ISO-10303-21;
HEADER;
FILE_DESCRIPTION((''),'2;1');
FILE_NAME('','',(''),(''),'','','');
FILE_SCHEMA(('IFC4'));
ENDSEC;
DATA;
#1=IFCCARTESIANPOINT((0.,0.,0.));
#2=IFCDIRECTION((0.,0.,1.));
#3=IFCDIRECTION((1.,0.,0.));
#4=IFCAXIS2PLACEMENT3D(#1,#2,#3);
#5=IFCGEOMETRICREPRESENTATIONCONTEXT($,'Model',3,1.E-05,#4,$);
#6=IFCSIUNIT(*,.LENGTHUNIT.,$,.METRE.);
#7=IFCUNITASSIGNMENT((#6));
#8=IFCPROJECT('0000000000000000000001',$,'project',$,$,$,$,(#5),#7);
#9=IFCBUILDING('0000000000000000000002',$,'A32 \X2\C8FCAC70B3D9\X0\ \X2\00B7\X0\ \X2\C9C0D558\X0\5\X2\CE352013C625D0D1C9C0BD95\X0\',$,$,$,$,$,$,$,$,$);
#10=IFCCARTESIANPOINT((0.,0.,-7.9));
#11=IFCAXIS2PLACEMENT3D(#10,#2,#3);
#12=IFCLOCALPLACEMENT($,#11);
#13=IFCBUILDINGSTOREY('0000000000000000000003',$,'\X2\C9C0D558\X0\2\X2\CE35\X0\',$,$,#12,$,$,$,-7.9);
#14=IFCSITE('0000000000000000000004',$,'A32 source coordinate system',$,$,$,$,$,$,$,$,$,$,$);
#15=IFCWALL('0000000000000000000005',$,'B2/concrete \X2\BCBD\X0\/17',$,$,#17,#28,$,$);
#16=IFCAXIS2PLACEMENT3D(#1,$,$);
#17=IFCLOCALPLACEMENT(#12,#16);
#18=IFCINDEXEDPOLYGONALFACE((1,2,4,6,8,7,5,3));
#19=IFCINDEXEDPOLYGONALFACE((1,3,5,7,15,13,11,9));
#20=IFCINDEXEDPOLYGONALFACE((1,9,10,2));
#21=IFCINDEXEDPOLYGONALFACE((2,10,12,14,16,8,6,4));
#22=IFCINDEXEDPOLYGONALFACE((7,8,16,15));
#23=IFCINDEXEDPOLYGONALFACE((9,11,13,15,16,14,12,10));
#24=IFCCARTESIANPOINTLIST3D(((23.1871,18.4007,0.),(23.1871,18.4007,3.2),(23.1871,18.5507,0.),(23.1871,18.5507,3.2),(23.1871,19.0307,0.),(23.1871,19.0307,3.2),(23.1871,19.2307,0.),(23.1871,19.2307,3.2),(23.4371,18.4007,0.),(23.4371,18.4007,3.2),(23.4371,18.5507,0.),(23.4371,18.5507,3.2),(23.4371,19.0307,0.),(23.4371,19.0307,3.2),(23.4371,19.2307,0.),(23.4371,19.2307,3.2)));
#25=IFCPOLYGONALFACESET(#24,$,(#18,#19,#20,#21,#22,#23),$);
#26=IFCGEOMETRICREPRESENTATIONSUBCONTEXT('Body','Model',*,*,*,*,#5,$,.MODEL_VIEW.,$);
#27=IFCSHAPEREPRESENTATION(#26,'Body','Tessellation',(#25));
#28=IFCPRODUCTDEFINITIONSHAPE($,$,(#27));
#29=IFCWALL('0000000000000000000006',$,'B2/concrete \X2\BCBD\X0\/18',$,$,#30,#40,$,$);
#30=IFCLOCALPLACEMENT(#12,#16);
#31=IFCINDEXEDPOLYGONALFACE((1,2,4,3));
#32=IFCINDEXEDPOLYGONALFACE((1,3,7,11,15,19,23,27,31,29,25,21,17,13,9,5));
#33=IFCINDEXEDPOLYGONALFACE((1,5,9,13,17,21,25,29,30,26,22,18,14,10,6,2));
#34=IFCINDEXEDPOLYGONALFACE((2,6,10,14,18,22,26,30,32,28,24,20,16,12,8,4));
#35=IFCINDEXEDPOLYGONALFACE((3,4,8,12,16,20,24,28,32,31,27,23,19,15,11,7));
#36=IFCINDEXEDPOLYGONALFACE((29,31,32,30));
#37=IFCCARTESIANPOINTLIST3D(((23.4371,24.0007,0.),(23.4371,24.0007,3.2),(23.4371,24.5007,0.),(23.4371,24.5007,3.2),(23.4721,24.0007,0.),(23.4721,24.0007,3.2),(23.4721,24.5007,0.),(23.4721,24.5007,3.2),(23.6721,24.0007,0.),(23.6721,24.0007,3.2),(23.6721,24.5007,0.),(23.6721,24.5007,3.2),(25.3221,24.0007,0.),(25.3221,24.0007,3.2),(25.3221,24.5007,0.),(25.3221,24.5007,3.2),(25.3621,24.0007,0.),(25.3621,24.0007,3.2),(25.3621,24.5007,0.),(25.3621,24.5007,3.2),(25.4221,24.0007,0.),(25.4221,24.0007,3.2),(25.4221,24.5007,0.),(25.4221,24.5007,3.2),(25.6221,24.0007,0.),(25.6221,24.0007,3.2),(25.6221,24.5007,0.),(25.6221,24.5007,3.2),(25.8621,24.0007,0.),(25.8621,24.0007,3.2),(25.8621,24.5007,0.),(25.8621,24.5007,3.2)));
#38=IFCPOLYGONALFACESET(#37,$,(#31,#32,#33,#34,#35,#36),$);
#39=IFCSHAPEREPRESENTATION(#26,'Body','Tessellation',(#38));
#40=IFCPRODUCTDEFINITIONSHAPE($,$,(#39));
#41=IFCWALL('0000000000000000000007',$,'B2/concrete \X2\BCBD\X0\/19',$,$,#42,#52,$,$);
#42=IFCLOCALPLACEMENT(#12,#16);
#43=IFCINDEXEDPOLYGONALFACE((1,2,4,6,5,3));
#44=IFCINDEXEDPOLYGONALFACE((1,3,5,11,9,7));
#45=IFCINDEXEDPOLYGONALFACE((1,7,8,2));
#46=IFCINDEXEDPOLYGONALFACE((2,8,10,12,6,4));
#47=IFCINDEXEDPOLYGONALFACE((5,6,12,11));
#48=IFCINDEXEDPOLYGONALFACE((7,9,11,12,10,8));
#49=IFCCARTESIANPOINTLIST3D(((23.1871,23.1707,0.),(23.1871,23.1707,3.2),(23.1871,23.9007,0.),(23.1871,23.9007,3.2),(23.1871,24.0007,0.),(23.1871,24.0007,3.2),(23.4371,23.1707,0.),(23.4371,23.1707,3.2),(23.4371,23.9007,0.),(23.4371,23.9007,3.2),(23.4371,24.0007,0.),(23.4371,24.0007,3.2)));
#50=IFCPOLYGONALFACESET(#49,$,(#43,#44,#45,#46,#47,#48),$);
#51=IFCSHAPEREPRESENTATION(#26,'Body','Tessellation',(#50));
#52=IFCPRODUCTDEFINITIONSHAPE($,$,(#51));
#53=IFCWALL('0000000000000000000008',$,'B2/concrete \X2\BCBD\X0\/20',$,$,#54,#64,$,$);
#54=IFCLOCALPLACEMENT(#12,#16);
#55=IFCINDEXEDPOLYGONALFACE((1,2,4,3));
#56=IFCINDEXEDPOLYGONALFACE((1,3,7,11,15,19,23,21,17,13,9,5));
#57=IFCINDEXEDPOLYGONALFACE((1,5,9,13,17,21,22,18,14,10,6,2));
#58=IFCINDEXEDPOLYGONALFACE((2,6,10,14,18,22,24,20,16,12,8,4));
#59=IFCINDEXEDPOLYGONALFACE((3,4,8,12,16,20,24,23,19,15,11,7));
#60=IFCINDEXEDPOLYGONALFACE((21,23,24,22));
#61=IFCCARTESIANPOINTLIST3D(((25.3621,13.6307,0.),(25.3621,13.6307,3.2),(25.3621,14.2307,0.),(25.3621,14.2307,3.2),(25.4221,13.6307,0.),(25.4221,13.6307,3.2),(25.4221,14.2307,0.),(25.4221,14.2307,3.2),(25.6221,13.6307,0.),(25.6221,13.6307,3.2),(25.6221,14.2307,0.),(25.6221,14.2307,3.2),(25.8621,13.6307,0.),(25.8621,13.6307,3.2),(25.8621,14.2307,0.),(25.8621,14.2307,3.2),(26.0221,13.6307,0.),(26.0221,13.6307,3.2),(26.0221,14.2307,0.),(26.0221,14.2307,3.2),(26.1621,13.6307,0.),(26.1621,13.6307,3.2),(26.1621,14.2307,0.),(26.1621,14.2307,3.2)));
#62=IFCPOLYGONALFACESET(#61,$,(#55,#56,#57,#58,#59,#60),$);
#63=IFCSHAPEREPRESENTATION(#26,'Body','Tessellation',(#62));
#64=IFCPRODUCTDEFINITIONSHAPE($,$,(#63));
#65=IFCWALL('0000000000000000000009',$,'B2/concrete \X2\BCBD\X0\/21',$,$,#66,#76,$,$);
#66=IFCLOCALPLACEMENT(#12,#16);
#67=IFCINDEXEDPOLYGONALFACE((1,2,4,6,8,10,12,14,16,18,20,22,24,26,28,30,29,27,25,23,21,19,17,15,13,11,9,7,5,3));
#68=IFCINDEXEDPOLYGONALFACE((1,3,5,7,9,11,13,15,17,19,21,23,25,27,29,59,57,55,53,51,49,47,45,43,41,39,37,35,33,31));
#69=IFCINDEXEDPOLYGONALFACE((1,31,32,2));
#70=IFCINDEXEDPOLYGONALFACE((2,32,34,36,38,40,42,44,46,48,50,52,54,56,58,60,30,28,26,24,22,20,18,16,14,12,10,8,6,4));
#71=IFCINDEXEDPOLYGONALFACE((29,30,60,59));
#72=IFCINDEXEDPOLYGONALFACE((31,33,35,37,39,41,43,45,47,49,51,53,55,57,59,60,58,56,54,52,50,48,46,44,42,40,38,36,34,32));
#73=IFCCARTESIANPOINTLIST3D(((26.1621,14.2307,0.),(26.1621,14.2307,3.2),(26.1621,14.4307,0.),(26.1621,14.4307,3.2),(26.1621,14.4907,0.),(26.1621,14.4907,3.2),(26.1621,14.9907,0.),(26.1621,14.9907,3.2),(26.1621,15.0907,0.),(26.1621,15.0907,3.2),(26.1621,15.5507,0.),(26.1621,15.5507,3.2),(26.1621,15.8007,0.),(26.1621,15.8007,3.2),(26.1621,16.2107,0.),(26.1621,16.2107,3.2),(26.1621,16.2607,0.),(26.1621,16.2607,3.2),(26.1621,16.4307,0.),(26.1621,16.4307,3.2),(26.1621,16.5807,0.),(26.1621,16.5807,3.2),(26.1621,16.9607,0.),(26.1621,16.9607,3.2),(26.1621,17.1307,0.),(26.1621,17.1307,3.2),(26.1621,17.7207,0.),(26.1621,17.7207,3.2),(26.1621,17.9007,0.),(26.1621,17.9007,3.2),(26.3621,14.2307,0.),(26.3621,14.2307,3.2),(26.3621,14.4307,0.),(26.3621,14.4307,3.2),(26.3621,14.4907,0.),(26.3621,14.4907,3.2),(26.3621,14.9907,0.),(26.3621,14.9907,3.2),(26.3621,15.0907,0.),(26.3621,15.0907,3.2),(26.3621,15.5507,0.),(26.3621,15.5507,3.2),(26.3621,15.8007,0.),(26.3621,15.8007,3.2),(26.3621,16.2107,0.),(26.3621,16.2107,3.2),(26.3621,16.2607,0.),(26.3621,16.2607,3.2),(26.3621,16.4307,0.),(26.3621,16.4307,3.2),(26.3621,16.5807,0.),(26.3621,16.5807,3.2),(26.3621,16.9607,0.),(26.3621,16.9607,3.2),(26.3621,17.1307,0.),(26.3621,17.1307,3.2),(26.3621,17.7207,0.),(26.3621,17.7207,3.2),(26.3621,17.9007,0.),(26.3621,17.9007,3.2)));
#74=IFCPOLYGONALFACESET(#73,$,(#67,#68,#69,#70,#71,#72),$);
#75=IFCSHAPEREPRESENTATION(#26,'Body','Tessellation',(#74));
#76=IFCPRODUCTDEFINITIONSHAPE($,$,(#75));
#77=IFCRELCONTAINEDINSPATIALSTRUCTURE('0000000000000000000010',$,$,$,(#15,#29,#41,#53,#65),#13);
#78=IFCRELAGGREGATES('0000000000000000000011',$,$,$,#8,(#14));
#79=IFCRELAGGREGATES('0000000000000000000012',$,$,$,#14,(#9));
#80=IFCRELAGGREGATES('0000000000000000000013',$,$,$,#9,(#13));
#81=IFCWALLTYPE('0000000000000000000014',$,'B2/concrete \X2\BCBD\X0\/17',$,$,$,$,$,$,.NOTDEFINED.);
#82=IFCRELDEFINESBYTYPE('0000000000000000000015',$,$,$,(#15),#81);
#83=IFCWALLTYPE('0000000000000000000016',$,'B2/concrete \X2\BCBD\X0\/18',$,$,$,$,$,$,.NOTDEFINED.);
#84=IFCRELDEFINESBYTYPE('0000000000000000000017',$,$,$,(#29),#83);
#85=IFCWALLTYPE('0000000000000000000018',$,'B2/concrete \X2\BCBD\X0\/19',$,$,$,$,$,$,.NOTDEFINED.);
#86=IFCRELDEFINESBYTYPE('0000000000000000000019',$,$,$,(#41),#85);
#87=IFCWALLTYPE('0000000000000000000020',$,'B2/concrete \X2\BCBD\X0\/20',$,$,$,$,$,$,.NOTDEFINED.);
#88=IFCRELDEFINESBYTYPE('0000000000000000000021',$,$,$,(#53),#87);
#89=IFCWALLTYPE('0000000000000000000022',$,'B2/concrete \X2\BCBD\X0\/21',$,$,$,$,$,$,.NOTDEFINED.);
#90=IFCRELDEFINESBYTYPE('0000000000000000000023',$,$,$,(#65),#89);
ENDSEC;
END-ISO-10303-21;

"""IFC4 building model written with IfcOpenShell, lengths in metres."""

from ifc_helpers import new_model, si_unit, frame, origin, origin_with_axes, place, context, subcontext, project, spatial, polyline, outline, extrude, source, transform, mapped, type_object, type_shapes, element, save


model = new_model("IFC4")

# Units and contexts
model_context = context("Model", 3, precision=1e-05, world=origin_with_axes())
body_context = subcontext(model_context, "Body", "Model", "MODEL_VIEW")
ifc_project = project(units=[si_unit("LENGTHUNIT", "METRE")], contexts=[model_context])

# Site, building, storey
site = spatial("IfcSite", under=ifc_project, Name="A32 source coordinate system")
building = spatial("IfcBuilding", under=site, Name="A32 주거동 · 지하5층–옥탑지붕")
storey_placement = place(None, frame((0.0, 0.0, -7.9), z_axis=(0.0, 0.0, 1.0), x_axis=(1.0, 0.0, 0.0)))
storey = spatial("IfcBuildingStorey", under=building, at=storey_placement, Name="지하2층", Elevation=-7.9)

# Walls
wall_type_1 = type_object("IfcWallType", Name="B2/concrete 벽/17", PredefinedType="NOTDEFINED")
shared_shape_1 = source(origin(), body_context, "Body", "SweptSolid", [
    extrude(outline(polyline([(23.1871, 19.0307), (23.1871, 19.2307), (23.4371, 19.2307), (23.4371, 19.0307), (23.4371, 18.5507), (23.4371, 18.4007), (23.1871, 18.4007), (23.1871, 18.5507), (23.1871, 19.0307)])), origin(), (0.0, 0.0, 1.0), 3.2),
])
type_shapes(wall_type_1, [shared_shape_1])
wall_1_placement = place(storey_placement, origin_with_axes())
element("IfcWall", 1, at=wall_1_placement, inside=storey, type_object=wall_type_1, Name="B2/concrete 벽/17", context=body_context, shape_type="MappedRepresentation", body=[
    mapped(shared_shape_1, transform((0.0, 0.0, 0.0), scale=1.0)),
])
wall_type_2 = type_object("IfcWallType", Name="B2/concrete 벽/18", PredefinedType="NOTDEFINED")
shared_shape_2 = source(origin(), body_context, "Body", "SweptSolid", [
    extrude(outline(polyline([(25.3621, 24.0007), (25.3221, 24.0007), (23.6721, 24.0007), (23.4721, 24.0007), (23.4371, 24.0007), (23.4371, 24.5007), (23.4721, 24.5007), (23.6721, 24.5007), (25.3221, 24.5007), (25.3621, 24.5007), (25.4221, 24.5007), (25.6221, 24.5007), (25.8621, 24.5007), (25.8621, 24.0007), (25.6221, 24.0007), (25.4221, 24.0007), (25.3621, 24.0007)])), origin(), (0.0, 0.0, 1.0), 3.2),
])
type_shapes(wall_type_2, [shared_shape_2])
wall_2_placement = place(storey_placement, origin_with_axes())
element("IfcWall", 2, at=wall_2_placement, inside=storey, type_object=wall_type_2, Name="B2/concrete 벽/18", context=body_context, shape_type="MappedRepresentation", body=[
    mapped(shared_shape_2, transform((0.0, 0.0, 0.0), scale=1.0)),
])
wall_type_3 = type_object("IfcWallType", Name="B2/concrete 벽/19", PredefinedType="NOTDEFINED")
shared_shape_3 = source(origin(), body_context, "Body", "SweptSolid", [
    extrude(outline(polyline([(23.1871, 23.1707), (23.1871, 23.9007), (23.1871, 24.0007), (23.4371, 24.0007), (23.4371, 23.9007), (23.4371, 23.1707), (23.1871, 23.1707)])), origin(), (0.0, 0.0, 1.0), 3.2),
])
type_shapes(wall_type_3, [shared_shape_3])
wall_3_placement = place(storey_placement, origin_with_axes())
element("IfcWall", 3, at=wall_3_placement, inside=storey, type_object=wall_type_3, Name="B2/concrete 벽/19", context=body_context, shape_type="MappedRepresentation", body=[
    mapped(shared_shape_3, transform((0.0, 0.0, 0.0), scale=1.0)),
])
wall_type_4 = type_object("IfcWallType", Name="B2/concrete 벽/20", PredefinedType="NOTDEFINED")
shared_shape_4 = source(origin(), body_context, "Body", "SweptSolid", [
    extrude(outline(polyline([(25.8621, 14.2307), (26.0221, 14.2307), (26.1621, 14.2307), (26.1621, 13.6307), (26.0221, 13.6307), (25.8621, 13.6307), (25.6221, 13.6307), (25.4221, 13.6307), (25.3621, 13.6307), (25.3621, 14.2307), (25.4221, 14.2307), (25.6221, 14.2307), (25.8621, 14.2307)])), origin(), (0.0, 0.0, 1.0), 3.2),
])
type_shapes(wall_type_4, [shared_shape_4])
wall_4_placement = place(storey_placement, origin_with_axes())
element("IfcWall", 4, at=wall_4_placement, inside=storey, type_object=wall_type_4, Name="B2/concrete 벽/20", context=body_context, shape_type="MappedRepresentation", body=[
    mapped(shared_shape_4, transform((0.0, 0.0, 0.0), scale=1.0)),
])
wall_type_5 = type_object("IfcWallType", Name="B2/concrete 벽/21", PredefinedType="NOTDEFINED")
shared_shape_5 = source(origin(), body_context, "Body", "SweptSolid", [
    extrude(outline(polyline([(26.1621, 14.9907), (26.1621, 15.0907), (26.1621, 15.5507), (26.1621, 15.8007), (26.1621, 16.2107), (26.1621, 16.2607), (26.1621, 16.4307), (26.1621, 16.5807), (26.1621, 16.9607), (26.1621, 17.1307), (26.1621, 17.7207), (26.1621, 17.9007), (26.3621, 17.9007), (26.3621, 17.7207), (26.3621, 17.1307), (26.3621, 16.9607), (26.3621, 16.5807), (26.3621, 16.4307), (26.3621, 16.2607), (26.3621, 16.2107), (26.3621, 15.8007), (26.3621, 15.5507), (26.3621, 15.0907), (26.3621, 14.9907), (26.3621, 14.4907), (26.3621, 14.4307), (26.3621, 14.2307), (26.1621, 14.2307), (26.1621, 14.4307), (26.1621, 14.4907), (26.1621, 14.9907)])), origin(), (0.0, 0.0, 1.0), 3.2),
])
type_shapes(wall_type_5, [shared_shape_5])
wall_5_placement = place(storey_placement, origin_with_axes())
element("IfcWall", 5, at=wall_5_placement, inside=storey, type_object=wall_type_5, Name="B2/concrete 벽/21", context=body_context, shape_type="MappedRepresentation", body=[
    mapped(shared_shape_5, transform((0.0, 0.0, 0.0), scale=1.0)),
])

save(model, "model.ifc")
